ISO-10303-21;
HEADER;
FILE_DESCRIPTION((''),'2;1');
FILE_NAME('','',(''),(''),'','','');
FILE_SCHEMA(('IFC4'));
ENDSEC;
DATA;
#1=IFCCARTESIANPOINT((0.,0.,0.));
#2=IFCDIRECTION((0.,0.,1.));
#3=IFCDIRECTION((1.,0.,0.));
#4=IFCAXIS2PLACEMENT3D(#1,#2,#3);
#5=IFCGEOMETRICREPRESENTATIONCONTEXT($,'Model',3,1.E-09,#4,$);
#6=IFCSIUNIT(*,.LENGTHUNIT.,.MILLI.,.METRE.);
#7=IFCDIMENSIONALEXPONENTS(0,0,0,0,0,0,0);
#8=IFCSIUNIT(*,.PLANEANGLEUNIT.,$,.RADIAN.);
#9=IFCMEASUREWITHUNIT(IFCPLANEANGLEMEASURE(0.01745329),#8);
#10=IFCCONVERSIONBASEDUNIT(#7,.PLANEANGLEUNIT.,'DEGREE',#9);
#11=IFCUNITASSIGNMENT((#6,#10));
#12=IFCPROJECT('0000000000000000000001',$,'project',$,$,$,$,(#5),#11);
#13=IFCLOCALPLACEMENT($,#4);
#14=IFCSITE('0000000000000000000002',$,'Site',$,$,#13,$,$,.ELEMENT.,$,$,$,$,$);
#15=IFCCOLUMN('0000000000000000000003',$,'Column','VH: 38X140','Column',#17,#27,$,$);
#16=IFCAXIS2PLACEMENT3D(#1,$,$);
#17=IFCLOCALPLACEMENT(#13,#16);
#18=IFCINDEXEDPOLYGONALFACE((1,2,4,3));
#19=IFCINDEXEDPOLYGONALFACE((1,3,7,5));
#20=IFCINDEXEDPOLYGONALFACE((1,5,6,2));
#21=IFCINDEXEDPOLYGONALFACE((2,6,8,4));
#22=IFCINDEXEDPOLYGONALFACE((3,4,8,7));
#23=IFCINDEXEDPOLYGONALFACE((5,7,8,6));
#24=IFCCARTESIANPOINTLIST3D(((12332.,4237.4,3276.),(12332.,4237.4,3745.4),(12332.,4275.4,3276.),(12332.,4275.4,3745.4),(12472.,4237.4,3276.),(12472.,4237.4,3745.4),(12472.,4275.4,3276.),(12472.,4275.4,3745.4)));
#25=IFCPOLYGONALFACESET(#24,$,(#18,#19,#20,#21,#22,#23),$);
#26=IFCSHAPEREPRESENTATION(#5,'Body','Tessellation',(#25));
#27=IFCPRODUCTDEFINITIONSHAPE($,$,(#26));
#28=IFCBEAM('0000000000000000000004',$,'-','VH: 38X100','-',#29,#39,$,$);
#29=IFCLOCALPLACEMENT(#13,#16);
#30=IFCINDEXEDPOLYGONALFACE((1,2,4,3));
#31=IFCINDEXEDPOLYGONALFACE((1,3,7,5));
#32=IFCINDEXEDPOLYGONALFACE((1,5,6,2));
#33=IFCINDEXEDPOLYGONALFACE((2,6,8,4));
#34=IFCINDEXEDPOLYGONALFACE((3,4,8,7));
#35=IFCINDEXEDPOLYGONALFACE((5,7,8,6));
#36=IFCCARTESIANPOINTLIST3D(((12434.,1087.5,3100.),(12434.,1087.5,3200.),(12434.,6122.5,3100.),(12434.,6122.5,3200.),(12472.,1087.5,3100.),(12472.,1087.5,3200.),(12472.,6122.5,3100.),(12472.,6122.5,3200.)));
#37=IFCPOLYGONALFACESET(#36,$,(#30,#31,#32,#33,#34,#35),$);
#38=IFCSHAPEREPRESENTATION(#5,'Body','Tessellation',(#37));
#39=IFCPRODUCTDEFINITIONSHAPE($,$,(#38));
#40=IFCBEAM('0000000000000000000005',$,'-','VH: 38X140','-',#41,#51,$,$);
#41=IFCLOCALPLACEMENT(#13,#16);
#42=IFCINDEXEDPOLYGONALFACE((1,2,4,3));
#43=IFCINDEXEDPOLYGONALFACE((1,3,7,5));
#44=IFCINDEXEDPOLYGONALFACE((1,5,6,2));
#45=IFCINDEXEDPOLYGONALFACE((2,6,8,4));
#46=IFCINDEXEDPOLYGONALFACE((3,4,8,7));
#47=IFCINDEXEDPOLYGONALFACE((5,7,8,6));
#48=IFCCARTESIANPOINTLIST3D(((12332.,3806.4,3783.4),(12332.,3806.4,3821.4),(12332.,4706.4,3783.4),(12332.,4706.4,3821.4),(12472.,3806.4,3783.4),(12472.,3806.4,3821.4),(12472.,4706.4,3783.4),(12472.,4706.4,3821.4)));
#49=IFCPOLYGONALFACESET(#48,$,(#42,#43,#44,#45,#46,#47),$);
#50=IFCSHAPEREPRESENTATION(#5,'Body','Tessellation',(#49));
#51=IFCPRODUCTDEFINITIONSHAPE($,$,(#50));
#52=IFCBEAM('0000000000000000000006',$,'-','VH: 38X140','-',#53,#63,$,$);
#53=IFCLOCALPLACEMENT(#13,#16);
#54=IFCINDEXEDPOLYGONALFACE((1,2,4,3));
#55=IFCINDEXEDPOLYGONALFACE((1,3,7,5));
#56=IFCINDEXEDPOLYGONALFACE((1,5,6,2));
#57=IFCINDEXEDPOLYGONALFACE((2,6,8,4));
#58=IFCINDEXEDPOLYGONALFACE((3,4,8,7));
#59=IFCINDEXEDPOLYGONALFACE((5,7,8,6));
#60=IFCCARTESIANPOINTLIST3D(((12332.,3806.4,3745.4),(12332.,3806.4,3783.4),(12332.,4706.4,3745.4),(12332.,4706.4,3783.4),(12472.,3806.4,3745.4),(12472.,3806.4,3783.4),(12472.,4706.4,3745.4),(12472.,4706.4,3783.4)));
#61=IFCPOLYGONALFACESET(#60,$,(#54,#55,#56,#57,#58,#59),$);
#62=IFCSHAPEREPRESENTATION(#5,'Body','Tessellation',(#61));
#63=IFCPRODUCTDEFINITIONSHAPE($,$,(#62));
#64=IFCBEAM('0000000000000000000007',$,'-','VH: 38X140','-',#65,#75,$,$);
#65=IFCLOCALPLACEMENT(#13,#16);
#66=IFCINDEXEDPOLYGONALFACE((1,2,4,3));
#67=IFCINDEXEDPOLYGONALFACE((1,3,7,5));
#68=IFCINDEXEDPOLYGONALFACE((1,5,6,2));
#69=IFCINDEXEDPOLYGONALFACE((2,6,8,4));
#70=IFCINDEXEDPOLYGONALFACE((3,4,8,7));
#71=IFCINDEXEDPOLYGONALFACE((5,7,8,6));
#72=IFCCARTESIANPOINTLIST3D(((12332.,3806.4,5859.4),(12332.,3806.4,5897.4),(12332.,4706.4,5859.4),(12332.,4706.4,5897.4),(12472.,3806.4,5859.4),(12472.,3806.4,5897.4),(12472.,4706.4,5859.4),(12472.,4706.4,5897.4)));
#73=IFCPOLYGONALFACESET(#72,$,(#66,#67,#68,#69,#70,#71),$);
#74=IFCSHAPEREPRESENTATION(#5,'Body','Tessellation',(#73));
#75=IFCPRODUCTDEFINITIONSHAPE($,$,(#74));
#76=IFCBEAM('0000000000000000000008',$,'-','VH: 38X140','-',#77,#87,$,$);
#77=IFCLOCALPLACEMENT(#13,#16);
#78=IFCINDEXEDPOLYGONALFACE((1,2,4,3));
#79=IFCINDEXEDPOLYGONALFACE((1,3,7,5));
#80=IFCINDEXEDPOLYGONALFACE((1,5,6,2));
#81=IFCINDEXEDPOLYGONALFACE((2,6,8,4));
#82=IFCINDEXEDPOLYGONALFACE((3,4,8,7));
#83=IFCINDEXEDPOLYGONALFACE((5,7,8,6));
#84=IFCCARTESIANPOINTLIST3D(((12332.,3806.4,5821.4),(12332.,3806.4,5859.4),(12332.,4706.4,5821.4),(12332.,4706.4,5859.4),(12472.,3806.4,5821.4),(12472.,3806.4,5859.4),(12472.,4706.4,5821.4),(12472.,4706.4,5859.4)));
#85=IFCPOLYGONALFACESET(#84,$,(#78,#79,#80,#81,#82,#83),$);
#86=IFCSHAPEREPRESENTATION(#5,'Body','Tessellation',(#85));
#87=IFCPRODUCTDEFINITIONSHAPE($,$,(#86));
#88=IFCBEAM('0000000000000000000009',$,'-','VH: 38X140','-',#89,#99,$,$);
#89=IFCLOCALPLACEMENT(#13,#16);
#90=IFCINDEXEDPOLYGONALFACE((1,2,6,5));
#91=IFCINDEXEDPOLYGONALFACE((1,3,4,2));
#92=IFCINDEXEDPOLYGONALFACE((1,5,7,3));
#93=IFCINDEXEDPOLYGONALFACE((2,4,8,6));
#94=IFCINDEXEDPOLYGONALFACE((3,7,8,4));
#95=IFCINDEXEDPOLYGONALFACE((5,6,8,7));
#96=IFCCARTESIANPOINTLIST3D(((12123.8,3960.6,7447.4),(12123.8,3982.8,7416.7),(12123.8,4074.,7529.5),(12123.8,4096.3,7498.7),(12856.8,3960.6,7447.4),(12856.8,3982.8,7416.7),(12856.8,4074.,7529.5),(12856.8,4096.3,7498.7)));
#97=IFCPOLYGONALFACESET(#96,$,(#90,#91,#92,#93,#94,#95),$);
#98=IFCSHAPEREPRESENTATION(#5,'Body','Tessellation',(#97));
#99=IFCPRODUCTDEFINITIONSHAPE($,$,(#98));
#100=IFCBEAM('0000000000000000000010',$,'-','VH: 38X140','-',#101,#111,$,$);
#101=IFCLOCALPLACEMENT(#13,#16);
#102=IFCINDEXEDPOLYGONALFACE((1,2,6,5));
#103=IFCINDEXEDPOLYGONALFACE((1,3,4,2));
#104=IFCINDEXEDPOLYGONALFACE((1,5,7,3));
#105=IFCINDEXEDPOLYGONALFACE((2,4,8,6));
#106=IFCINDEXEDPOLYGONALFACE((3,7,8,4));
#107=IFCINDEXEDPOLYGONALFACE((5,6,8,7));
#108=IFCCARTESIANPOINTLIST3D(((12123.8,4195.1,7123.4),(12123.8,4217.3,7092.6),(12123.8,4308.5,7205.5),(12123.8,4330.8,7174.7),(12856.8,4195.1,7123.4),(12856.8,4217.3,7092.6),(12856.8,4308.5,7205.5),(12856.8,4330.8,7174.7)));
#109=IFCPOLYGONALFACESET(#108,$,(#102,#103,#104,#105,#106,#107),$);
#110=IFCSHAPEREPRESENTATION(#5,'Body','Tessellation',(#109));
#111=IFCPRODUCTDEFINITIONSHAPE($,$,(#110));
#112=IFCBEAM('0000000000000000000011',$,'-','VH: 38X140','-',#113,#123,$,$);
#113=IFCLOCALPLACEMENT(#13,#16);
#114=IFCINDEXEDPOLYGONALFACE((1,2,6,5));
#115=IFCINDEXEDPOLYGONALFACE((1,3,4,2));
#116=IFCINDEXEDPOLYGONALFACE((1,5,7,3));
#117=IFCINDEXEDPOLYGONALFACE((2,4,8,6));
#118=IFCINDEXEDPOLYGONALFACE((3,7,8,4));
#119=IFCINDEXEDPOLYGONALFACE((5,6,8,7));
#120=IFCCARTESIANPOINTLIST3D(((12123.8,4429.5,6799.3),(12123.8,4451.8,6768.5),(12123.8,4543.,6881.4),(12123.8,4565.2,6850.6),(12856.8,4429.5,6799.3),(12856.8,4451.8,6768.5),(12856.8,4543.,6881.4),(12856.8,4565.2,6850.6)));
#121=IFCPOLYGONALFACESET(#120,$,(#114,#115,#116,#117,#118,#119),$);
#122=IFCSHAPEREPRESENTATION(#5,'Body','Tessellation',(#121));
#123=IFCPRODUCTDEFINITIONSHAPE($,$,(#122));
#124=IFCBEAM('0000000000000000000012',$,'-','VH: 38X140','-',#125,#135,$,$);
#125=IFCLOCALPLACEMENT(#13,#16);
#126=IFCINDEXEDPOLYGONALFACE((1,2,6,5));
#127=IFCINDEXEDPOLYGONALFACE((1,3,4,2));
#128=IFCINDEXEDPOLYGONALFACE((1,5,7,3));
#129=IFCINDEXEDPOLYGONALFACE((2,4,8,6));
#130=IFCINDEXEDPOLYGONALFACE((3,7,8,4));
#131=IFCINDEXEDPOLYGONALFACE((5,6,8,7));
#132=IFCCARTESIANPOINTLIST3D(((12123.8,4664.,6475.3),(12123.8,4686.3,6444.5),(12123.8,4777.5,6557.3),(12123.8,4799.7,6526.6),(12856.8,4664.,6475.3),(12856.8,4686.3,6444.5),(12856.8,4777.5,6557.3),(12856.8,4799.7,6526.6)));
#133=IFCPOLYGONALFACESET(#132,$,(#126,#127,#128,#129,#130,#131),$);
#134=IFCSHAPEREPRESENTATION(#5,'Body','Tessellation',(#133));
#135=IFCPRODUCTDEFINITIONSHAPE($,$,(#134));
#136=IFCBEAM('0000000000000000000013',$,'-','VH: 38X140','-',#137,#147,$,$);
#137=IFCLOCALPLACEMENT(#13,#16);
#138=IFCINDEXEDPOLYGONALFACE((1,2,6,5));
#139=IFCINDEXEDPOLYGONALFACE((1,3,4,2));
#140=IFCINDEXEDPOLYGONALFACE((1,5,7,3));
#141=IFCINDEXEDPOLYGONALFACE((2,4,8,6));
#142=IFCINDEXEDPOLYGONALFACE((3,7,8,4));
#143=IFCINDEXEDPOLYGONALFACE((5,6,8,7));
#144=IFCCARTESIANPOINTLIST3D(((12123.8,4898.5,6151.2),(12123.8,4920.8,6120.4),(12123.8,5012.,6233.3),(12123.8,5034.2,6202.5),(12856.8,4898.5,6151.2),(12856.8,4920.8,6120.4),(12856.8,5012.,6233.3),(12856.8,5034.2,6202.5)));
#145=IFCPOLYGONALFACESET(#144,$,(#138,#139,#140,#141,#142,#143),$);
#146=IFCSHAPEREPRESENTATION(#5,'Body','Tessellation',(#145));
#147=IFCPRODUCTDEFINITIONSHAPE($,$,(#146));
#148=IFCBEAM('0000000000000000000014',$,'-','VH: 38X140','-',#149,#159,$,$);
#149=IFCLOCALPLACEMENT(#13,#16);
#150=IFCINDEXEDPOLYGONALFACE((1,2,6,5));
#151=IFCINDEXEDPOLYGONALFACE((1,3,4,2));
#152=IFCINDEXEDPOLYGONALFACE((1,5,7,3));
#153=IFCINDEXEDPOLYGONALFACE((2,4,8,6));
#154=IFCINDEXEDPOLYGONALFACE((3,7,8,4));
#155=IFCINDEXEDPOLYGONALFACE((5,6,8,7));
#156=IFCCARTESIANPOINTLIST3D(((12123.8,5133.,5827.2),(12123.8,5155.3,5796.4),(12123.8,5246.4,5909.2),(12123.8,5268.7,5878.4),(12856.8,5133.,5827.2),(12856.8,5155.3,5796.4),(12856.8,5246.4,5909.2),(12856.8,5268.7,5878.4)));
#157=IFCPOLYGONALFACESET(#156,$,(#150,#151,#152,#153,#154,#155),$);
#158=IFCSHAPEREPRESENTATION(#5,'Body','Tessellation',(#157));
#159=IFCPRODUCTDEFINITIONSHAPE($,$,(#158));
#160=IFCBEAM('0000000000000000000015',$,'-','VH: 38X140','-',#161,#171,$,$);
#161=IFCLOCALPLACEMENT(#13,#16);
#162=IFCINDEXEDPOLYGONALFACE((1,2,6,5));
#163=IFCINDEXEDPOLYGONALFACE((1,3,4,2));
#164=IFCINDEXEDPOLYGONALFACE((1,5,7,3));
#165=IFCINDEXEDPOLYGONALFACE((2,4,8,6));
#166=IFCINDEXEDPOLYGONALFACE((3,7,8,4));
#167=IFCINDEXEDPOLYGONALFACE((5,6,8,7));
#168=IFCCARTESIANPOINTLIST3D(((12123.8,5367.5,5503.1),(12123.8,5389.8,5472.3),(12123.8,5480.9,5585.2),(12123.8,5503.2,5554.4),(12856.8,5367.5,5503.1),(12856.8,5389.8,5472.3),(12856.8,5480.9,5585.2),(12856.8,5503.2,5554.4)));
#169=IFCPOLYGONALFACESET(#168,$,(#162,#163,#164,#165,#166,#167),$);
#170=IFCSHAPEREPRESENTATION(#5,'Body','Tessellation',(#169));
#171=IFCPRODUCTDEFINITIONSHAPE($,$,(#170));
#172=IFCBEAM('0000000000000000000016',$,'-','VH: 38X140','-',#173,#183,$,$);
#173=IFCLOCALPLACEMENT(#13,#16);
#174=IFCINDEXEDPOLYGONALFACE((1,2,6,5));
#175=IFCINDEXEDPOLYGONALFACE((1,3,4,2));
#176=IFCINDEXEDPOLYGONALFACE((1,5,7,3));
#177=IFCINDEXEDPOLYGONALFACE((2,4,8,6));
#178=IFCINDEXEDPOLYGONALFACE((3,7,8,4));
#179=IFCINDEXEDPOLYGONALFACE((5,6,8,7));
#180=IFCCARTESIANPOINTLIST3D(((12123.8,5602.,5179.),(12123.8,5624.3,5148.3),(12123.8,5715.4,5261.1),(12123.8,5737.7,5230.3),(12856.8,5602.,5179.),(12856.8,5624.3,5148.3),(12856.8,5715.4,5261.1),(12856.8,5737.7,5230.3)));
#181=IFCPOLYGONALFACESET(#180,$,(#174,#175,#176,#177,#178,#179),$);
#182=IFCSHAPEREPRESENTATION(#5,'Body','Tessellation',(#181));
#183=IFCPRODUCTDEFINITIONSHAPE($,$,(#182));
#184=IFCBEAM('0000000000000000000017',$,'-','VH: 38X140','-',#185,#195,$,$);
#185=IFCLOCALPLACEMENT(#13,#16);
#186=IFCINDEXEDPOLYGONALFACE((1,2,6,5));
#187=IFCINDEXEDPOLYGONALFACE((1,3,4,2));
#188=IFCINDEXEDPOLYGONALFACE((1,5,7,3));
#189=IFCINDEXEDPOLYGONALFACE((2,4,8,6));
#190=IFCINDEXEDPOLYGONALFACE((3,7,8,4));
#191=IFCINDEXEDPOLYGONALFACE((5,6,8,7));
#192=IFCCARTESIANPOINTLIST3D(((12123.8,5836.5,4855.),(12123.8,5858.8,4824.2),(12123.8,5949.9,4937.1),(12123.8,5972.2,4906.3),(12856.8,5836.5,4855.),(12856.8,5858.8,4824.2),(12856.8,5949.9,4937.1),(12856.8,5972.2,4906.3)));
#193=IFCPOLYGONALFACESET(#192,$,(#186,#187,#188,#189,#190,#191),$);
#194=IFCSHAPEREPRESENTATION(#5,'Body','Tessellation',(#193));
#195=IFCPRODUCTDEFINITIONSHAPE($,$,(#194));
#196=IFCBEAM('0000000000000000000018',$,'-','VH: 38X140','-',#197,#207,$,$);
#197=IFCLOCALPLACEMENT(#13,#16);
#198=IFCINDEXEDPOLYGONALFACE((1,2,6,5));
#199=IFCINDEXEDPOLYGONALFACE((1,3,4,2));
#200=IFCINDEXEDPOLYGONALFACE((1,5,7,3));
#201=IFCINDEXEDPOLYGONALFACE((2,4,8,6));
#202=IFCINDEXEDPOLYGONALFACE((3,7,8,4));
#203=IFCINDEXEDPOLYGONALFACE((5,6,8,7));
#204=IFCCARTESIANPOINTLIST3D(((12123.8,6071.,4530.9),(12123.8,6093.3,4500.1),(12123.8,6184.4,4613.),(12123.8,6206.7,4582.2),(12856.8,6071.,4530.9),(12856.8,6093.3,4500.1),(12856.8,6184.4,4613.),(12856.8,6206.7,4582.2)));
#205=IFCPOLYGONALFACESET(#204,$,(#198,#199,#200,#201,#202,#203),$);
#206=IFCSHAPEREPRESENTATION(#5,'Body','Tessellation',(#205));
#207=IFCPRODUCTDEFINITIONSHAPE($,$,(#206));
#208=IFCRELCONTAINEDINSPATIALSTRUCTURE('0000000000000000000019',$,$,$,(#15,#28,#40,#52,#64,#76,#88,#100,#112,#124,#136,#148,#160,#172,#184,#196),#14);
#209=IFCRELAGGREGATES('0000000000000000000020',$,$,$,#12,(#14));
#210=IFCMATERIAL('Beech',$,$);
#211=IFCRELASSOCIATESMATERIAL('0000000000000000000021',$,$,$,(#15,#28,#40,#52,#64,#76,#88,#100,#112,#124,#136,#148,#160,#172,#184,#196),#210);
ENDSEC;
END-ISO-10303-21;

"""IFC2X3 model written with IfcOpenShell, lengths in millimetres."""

from ifc_helpers import new_model, entity, si_unit, converted_unit, frame, origin, origin_with_axes, origin_2d, place, context, project, spatial, rectangle, extrude, material, element, save


model = new_model("IFC2X3")

# Units and contexts
model_context = context("Model", 3, precision=1e-09, world=origin_with_axes())
ifc_project = project(units=[si_unit("LENGTHUNIT", "METRE", prefix="MILLI"), converted_unit("PLANEANGLEUNIT", "DEGREE", entity("IfcPlaneAngleMeasure", 0.01745329), si_unit("PLANEANGLEUNIT", "RADIAN"), dimensions=[0, 0, 0, 0, 0, 0, 0])], contexts=[model_context])

# Site
site_placement = place(None, origin_with_axes())
site = spatial("IfcSite", under=ifc_project, at=site_placement, Name="Site", CompositionType="ELEMENT")

# Column
ifc_material = material(Name="Beech")
column_1_placement = place(None, frame((12402.0, 4256.4, 3276.0), z_axis=(0.0, 0.0, 1.0), x_axis=(0.0, -1.0, 0.0)))
element("IfcColumn", 1, at=column_1_placement, inside=site, material=ifc_material, Name="Column", Description="VH: 38X140", ObjectType="Column", context=model_context, shape_type="SweptSolid", body=[
    extrude(rectangle(XDim=38.0, YDim=140.0, at=origin_2d()), origin(), (0.0, 0.0, 1.0), 469.4),
])

# Beams
beam_placement = place(None, frame((12453.0, 6122.5, 3150.0), z_axis=(0.000003, -1.0, 0.0), x_axis=(1.0, 0.000003, 0.0)))
element("IfcBeam", 2, at=beam_placement, inside=site, material=ifc_material, Name="-", Description="VH: 38X100", ObjectType="-", context=model_context, shape_type="SweptSolid", body=[
    extrude(rectangle(XDim=38.0, YDim=100.0, at=origin_2d()), origin(), (0.0, 0.0, 1.0), 5035.0),
])
for number, where, z_axis, x_axis, name in (
    (3, (12402.0, 4706.4, 3802.4), (0.0, -1.0, 0.0), (0.0, 0.0, -1.0), "-"),
    (4, (12402.0, 4706.4, 3764.4), (0.0, -1.0, 0.0), (0.0, 0.0, -1.0), "-"),
    (5, (12402.0, 4706.4, 5878.4), (0.0, -1.0, 0.0), (0.0, 0.0, -1.0), "-"),
    (6, (12402.0, 4706.4, 5840.4), (0.0, -1.0, 0.0), (0.0, 0.0, -1.0), "-"),
):
    element("IfcBeam", number, at=place(None, frame(where, z_axis=z_axis, x_axis=x_axis)), inside=site, material=ifc_material, Name=name, Description="VH: 38X140", ObjectType="-", context=model_context, shape_type="SweptSolid", body=[
        extrude(rectangle(XDim=38.0, YDim=140.0, at=origin_2d()), origin(), (0.0, 0.0, 1.0), 900.0),
    ])
for number, where, z_axis, x_axis, name in (
    (7, (12856.8, 4028.4, 7473.1), (-1.0, 0.0, 0.0), (0.0, -0.58623, 0.810145), "-"),
    (8, (12856.8, 4262.9, 7149.0), (-1.0, 0.0, 0.0), (0.0, -0.58623, 0.810145), "-"),
    (9, (12856.8, 4497.4, 6825.0), (-1.0, 0.0, 0.0), (0.0, -0.58623, 0.810145), "-"),
    (10, (12856.8, 4731.9, 6500.9), (-1.0, 0.0, 0.0), (0.0, -0.58623, 0.810145), "-"),
    (11, (12856.8, 4966.4, 6176.9), (-1.0, 0.0, 0.0), (0.0, -0.58623, 0.810145), "-"),
    (12, (12856.8, 5200.9, 5852.8), (-1.0, 0.0, 0.0), (0.0, -0.58623, 0.810145), "-"),
    (13, (12856.8, 5435.4, 5528.7), (-1.0, 0.0, 0.0), (0.0, -0.58623, 0.810145), "-"),
    (14, (12856.8, 5669.9, 5204.7), (-1.0, 0.0, 0.0), (0.0, -0.58623, 0.810145), "-"),
    (15, (12856.8, 5904.3, 4880.6), (-1.0, 0.0, 0.0), (0.0, -0.58623, 0.810145), "-"),
    (16, (12856.8, 6138.8, 4556.6), (-1.0, 0.0, 0.0), (0.0, -0.58623, 0.810145), "-"),
):
    element("IfcBeam", number, at=place(None, frame(where, z_axis=z_axis, x_axis=x_axis)), inside=site, material=ifc_material, Name=name, Description="VH: 38X140", ObjectType="-", context=model_context, shape_type="SweptSolid", body=[
        extrude(rectangle(XDim=38.0, YDim=140.0, at=origin_2d()), origin(), (0.0, 0.0, 1.0), 733.0),
    ])

save(model, "model.ifc")
